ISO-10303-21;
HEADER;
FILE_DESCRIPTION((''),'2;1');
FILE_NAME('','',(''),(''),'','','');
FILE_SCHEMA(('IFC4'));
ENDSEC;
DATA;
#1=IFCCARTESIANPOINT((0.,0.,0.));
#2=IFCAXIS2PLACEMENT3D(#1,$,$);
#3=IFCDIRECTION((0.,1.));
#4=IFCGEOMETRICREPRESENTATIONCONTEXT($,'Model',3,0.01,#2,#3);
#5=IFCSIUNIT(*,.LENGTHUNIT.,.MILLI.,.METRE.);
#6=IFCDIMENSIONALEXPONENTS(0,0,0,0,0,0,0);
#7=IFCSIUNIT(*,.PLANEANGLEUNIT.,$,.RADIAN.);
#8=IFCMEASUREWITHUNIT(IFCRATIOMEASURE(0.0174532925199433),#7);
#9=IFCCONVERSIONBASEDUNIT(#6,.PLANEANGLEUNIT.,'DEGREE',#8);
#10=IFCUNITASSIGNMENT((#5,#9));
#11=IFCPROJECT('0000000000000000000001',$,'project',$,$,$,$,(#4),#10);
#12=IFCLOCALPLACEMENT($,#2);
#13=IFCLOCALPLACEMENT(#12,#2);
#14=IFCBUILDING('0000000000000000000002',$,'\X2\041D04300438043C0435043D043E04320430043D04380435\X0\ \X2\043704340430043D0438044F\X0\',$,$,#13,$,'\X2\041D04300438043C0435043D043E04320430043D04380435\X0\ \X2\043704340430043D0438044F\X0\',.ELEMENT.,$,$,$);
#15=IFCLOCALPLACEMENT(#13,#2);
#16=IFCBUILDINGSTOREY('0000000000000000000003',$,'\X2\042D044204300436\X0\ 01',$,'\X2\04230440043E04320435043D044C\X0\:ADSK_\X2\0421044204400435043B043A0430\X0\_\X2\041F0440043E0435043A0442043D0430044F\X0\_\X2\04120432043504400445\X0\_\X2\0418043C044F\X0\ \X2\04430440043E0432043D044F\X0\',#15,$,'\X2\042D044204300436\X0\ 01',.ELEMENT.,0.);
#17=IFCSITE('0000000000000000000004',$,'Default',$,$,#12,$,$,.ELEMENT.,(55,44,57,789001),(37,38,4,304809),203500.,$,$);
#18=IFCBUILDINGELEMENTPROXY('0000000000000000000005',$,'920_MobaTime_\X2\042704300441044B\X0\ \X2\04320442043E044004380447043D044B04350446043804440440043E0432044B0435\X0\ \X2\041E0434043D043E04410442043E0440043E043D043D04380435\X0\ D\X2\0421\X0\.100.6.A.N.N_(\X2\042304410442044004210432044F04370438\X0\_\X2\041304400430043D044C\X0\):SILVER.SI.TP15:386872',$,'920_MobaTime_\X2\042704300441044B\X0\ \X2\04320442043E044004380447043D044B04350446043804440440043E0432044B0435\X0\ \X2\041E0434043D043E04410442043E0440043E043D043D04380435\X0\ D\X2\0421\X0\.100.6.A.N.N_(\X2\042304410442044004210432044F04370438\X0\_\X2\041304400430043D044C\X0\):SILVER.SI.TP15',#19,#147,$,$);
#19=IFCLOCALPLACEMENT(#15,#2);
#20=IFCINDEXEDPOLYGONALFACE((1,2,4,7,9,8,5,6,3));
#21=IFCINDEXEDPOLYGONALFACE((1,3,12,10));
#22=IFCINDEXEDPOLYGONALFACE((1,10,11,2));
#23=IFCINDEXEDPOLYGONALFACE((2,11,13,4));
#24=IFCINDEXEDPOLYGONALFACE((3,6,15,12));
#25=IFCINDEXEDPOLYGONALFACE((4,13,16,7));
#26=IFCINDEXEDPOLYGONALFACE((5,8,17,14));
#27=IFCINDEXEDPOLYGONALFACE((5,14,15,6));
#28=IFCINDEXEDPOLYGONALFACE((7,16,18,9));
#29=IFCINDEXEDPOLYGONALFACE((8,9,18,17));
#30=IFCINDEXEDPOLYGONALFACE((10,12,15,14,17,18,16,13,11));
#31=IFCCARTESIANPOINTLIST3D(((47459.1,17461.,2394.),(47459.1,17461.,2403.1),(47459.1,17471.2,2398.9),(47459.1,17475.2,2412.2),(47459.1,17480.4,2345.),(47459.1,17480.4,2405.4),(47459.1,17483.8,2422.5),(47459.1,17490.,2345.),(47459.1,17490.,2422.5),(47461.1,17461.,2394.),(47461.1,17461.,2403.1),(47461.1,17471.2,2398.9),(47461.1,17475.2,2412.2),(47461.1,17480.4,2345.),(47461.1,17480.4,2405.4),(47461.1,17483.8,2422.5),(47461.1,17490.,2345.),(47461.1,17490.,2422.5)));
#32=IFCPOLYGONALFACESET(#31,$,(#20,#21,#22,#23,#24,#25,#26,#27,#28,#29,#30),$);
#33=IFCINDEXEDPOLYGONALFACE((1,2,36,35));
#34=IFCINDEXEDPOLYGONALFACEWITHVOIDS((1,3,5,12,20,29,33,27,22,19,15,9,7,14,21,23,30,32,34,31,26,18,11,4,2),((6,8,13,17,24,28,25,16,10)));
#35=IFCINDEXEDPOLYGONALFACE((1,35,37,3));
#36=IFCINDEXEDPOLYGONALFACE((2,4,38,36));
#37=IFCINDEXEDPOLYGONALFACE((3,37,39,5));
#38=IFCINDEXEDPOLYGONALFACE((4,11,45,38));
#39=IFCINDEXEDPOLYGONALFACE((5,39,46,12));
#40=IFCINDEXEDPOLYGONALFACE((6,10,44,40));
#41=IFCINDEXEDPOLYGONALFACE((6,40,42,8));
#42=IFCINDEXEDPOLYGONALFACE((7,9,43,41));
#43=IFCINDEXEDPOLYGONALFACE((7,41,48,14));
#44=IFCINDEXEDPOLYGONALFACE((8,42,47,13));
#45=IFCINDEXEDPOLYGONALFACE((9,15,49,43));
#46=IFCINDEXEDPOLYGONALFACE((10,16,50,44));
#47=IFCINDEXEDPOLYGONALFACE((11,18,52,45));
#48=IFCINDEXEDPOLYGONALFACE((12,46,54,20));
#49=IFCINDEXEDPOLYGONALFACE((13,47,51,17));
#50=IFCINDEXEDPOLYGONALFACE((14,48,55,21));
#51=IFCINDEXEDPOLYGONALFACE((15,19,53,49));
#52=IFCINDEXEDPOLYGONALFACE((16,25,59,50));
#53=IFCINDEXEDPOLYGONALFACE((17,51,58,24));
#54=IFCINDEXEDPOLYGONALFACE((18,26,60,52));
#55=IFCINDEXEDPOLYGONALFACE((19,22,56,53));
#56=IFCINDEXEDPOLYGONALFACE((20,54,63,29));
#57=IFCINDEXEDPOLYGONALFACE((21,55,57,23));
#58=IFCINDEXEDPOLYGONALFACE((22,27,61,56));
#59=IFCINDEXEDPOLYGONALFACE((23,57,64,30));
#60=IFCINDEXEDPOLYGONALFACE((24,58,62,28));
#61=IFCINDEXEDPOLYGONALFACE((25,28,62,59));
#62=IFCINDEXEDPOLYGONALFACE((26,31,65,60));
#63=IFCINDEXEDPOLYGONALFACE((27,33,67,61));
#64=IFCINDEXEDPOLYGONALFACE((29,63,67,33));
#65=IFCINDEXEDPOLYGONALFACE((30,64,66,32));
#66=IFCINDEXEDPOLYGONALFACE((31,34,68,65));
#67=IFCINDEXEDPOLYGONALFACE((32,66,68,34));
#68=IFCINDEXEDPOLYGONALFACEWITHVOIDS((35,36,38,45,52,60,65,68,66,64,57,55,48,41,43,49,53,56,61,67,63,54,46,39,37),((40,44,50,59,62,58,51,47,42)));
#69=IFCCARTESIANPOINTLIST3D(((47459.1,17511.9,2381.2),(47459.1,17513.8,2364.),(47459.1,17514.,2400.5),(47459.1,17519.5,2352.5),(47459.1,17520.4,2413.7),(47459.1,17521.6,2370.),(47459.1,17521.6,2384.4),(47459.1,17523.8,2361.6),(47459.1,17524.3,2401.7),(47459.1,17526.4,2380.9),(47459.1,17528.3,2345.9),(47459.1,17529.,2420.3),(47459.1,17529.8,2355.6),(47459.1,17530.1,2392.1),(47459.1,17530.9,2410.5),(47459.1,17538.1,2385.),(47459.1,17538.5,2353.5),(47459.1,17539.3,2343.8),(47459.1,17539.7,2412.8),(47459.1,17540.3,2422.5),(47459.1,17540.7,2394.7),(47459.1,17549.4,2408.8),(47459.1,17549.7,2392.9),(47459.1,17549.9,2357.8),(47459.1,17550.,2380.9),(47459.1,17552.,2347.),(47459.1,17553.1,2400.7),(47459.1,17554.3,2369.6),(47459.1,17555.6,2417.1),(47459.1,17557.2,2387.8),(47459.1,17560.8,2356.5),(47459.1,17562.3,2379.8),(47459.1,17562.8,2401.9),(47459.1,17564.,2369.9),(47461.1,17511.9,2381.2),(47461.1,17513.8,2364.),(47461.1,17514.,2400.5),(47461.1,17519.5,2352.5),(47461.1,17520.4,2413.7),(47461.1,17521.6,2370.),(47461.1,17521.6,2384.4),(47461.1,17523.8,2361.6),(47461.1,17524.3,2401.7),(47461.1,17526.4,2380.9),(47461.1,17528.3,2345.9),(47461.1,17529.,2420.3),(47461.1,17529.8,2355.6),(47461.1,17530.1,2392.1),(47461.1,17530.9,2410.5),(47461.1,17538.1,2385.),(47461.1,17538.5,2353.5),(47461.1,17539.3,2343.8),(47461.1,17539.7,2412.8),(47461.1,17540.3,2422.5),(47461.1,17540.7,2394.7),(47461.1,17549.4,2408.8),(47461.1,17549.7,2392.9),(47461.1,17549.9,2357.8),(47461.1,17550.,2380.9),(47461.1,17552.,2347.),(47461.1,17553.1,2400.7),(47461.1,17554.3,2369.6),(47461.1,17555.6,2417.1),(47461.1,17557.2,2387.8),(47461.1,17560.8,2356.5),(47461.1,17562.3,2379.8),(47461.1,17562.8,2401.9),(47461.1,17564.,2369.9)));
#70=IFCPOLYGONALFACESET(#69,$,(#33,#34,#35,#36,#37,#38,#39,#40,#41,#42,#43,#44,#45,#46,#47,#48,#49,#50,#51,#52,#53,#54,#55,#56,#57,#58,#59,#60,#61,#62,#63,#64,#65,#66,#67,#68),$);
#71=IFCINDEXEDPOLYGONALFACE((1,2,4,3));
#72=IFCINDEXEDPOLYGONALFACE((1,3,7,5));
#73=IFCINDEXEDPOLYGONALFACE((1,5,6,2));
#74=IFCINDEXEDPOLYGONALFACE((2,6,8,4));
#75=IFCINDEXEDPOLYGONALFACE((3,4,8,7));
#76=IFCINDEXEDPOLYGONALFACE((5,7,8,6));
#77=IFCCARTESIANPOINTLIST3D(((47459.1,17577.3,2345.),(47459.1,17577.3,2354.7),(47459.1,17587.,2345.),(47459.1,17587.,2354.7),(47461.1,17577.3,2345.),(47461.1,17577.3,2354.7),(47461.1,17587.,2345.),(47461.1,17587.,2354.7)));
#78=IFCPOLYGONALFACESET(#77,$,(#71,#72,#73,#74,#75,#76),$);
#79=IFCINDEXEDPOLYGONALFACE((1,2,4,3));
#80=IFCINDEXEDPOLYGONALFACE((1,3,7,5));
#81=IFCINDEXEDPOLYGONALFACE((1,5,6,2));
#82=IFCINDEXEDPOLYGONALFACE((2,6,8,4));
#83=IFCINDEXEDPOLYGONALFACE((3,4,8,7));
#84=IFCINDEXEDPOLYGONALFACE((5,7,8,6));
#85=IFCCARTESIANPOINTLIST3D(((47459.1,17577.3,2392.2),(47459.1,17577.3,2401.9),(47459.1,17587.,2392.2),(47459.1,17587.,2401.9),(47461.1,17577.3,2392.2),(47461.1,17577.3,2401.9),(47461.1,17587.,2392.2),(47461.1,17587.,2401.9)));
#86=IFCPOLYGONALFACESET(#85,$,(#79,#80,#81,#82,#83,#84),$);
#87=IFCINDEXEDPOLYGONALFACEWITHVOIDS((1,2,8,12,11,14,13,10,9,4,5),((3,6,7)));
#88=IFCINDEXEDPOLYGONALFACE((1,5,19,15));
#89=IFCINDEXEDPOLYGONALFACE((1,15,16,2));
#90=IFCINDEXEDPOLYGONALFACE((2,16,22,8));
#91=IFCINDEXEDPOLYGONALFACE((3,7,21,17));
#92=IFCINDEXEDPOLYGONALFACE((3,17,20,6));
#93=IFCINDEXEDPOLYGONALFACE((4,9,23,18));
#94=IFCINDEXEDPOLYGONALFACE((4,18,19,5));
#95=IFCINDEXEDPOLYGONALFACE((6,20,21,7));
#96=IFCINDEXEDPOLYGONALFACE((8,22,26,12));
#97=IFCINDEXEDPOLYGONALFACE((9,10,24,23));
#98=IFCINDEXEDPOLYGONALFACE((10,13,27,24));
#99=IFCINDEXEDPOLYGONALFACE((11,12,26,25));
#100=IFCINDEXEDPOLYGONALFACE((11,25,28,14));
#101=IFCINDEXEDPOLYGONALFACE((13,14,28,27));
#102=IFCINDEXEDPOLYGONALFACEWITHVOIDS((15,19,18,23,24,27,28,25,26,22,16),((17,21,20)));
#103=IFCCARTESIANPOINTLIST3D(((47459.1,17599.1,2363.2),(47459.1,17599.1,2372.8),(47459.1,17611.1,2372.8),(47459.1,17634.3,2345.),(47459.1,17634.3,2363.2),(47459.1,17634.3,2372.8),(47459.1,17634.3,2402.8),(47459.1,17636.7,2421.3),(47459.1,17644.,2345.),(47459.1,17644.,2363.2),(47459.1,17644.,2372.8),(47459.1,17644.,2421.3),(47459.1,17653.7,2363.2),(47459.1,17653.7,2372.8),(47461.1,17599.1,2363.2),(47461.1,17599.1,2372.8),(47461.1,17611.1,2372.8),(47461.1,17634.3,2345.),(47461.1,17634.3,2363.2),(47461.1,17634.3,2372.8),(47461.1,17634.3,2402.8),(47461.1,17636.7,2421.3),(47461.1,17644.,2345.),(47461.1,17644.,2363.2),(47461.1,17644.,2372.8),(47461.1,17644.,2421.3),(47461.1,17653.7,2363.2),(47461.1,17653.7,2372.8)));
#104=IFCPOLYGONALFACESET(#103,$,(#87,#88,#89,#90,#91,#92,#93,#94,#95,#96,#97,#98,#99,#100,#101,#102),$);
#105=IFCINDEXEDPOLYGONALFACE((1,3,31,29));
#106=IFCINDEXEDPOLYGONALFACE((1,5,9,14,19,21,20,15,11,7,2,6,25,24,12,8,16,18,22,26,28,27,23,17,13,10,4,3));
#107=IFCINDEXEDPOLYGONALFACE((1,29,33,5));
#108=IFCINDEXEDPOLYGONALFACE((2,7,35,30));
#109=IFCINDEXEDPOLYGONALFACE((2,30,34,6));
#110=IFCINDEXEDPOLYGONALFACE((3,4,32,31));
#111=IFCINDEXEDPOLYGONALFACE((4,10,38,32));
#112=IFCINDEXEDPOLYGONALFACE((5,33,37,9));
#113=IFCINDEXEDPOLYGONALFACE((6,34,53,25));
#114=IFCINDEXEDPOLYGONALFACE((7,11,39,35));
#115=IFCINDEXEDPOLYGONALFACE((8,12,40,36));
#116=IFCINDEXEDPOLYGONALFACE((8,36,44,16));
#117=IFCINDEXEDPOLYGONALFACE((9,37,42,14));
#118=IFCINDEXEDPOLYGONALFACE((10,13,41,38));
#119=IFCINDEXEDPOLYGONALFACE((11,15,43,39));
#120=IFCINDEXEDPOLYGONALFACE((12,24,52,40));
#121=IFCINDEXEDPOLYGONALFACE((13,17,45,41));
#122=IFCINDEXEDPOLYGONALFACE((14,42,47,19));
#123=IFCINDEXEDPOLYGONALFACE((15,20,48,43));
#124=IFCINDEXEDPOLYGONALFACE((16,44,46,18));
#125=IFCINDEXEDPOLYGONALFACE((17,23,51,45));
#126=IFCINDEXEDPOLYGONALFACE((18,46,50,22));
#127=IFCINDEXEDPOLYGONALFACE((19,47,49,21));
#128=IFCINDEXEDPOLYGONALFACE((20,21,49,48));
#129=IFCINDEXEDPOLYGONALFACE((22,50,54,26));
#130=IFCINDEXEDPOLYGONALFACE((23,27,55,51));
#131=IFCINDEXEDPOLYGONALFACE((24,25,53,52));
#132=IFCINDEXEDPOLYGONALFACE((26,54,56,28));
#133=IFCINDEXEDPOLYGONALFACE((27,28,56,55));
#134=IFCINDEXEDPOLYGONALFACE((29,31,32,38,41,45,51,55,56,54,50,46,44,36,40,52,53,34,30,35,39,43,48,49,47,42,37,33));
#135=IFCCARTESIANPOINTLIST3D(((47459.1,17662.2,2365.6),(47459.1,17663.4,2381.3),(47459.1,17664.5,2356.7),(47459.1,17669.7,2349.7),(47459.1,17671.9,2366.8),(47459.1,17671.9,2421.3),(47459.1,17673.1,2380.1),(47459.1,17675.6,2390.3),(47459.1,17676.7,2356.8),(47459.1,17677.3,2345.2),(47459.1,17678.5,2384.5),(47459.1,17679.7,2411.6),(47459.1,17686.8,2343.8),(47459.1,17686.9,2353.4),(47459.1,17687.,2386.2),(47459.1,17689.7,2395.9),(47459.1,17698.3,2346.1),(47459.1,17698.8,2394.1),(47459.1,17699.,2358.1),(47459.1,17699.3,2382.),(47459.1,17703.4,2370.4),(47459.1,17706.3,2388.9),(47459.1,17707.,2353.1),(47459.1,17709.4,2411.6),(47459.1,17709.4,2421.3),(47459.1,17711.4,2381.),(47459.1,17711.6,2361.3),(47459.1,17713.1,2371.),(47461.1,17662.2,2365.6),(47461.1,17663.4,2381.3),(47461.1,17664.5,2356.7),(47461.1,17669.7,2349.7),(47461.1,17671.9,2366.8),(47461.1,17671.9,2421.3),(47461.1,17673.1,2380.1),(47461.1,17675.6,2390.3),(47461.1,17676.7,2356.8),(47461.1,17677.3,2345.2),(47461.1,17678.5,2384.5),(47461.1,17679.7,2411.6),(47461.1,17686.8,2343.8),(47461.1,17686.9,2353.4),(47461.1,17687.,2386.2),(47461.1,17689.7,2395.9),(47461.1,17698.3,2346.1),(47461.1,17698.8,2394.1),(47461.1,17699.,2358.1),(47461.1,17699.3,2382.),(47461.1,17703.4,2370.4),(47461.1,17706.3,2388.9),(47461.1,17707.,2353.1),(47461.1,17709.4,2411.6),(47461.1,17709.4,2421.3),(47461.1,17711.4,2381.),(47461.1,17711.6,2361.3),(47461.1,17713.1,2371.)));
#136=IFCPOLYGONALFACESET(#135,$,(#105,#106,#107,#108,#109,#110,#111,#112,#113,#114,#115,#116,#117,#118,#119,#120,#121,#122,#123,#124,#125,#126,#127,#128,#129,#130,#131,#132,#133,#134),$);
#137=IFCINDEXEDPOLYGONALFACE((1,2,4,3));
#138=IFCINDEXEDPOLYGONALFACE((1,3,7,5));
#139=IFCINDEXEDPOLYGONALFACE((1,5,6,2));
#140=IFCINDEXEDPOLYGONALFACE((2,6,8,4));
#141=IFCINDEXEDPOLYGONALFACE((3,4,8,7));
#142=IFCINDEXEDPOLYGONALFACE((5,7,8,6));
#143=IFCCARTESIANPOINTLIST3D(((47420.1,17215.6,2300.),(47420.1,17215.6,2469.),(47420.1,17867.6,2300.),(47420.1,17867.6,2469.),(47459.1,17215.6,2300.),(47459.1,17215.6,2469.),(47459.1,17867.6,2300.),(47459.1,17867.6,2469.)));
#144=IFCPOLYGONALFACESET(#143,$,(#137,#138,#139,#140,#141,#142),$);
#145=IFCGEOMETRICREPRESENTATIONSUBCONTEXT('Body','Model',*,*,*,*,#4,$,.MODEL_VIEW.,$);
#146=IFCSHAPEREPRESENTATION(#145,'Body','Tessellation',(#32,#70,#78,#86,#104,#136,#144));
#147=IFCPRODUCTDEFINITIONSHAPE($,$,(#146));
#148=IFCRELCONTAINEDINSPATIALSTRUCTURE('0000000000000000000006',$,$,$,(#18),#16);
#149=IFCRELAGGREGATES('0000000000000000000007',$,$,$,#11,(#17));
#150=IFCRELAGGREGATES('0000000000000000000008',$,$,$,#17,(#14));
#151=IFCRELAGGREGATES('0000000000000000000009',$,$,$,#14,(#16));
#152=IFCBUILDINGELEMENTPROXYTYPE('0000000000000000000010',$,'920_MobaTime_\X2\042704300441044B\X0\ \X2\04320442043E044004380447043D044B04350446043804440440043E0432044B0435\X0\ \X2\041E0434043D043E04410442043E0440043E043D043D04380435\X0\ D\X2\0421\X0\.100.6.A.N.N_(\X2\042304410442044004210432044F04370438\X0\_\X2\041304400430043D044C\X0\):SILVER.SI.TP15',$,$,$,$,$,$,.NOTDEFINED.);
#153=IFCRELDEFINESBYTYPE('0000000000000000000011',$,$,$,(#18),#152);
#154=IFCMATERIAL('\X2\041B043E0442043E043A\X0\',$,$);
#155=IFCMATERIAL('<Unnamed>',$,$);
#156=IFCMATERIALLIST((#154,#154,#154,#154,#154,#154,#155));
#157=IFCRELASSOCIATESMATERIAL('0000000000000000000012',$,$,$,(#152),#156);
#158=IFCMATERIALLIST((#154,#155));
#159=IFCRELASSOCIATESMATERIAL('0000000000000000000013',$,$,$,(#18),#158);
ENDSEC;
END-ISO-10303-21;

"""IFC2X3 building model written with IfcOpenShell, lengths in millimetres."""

from ifc_helpers import new_model, entity, si_unit, converted_unit, direction, frame, origin, origin_2d_with_axis, place, context, subcontext, project, spatial, polyline, rectangle, outline, extrude, source, transform, mapped, material, material_list, type_object, type_shapes, element, save


model = new_model("IFC2X3")

# Units and contexts
model_context = context("Model", 3, precision=0.01, world=origin(), true_north=direction((0.0, 1.0)))
body_context = subcontext(model_context, "Body", "Model", "MODEL_VIEW")
ifc_project = project(units=[si_unit("LENGTHUNIT", "METRE", prefix="MILLI"), converted_unit("PLANEANGLEUNIT", "DEGREE", entity("IfcRatioMeasure", 0.0174532925199433), si_unit("PLANEANGLEUNIT", "RADIAN"), dimensions=[0, 0, 0, 0, 0, 0, 0])], contexts=[model_context])

# Site, building, storey
site_placement = place(None, origin())
site = spatial("IfcSite", under=ifc_project, at=site_placement, Name="Default", CompositionType="ELEMENT", RefLatitude=(55, 44, 57, 789001), RefLongitude=(37, 38, 4, 304809), RefElevation=203500.0)
building_placement = place(site_placement, origin())
building = spatial("IfcBuilding", under=site, at=building_placement, Name="Наименование здания", LongName="Наименование здания", CompositionType="ELEMENT")
storey_placement = place(building_placement, origin())
storey = spatial("IfcBuildingStorey", under=building, at=storey_placement, Name="Этаж 01", ObjectType="Уровень:ADSK_Стрелка_Проектная_Вверх_Имя уровня", LongName="Этаж 01", CompositionType="ELEMENT", Elevation=0.0)

# Building element proxy
ifc_material_1 = material(Name="Лоток")
ifc_material_2 = material(Name="<Unnamed>")
ifc_material_list_1 = material_list([ifc_material_1, ifc_material_1, ifc_material_1, ifc_material_1, ifc_material_1, ifc_material_1, ifc_material_2])
building_element_proxy_type = type_object("IfcBuildingElementProxyType", Name="920_MobaTime_Часы вторичныецифровые Односторонние DС.100.6.A.N.N_(УстрСвязи_Грань):SILVER.SI.TP15", PredefinedType="NOTDEFINED", material=ifc_material_list_1)
shared_shape = source(origin(), body_context, "Body", "SweptSolid", [
    extrude(outline(polyline([(-49.3, -13.1), (28.2, -13.1), (28.2, -6.8), (17.9, 1.8), (8.8, 16.0), (-0.3, 16.0), (4.6, 5.8), (11.1, -3.4), (-49.3, -3.4), (-49.3, -13.1)])), frame((-64.6, 9.8, 39.0), z_axis=(0.0, 0.0, 1.0), x_axis=(0.0, 1.0, 0.0)), (0.0, 0.0, 1.0), 2.0),
    extrude(outline(polyline([(2.2, -27.6), (19.0, -27.6), (30.5, -16.1), (33.3, -4.9), (31.0, 5.8), (21.8, 17.2), (5.2, 27.3), (-11.1, 33.0), (-24.0, 32.7), (-33.6, 27.6), (-40.3, 18.6), (-42.8, 5.7), (-38.0, -6.3), (-27.2, -14.9), (-17.5, -17.7), (-8.2, -16.4), (-0.3, -11.9), (5.1, -4.5), (7.3, 6.2), (4.0, 17.2), (18.4, 7.3), (23.6, -2.4), (22.0, -11.4), (14.2, -18.4), (5.3, -18.3), (2.2, -27.6)]), holes=[polyline([(-9.0, 23.3), (-1.3, 14.3), (-2.5, 2.0), (-11.4, -7.0), (-23.4, -6.0), (-32.2, 2.9), (-31.2, 15.1), (-25.6, 22.1), (-17.5, 24.9), (-9.0, 23.3)])]), frame((-2.7, 3.6, 39.0), z_axis=(0.0, 0.0, 1.0), x_axis=(-0.427649, 0.903945, 0.0)), (0.0, 0.0, 1.0), 2.0),
    extrude(rectangle(XDim=9.7, YDim=9.7, at=origin_2d_with_axis()), frame((40.6, -34.7, 39.0)), (0.0, 0.0, 1.0), 2.0),
    extrude(rectangle(XDim=9.7, YDim=9.7, at=origin_2d_with_axis()), frame((40.6, 12.6, 39.0)), (0.0, 0.0, 1.0), 2.0),
    extrude(outline(polyline([(-0.9, -28.1), (8.8, -28.1), (8.8, -9.9), (18.5, -9.9), (18.5, -0.2), (8.8, -0.2), (8.8, 48.3), (1.5, 48.3), (-36.0, -0.2), (-36.0, -9.9), (-0.9, -9.9), (-0.9, -28.1)]), holes=[polyline([(-0.9, -0.2), (-24.1, -0.2), (-0.9, 29.7), (-0.9, -0.2)])]), frame((93.6, -11.4, 39.0)), (0.0, 0.0, 1.0), 2.0),
    extrude(outline(polyline([(3.3, -28.3), (12.5, -28.3), (20.5, -25.0), (26.8, -18.9), (30.7, -10.0), (31.4, 1.6), (26.9, 11.8), (20.1, 18.4), (11.1, 22.3), (1.0, 23.3), (-7.9, 20.4), (-14.9, 14.5), (-18.9, 6.2), (-17.1, -9.0), (-36.7, 0.5), (-29.1, 29.2), (-38.5, 31.7), (-48.1, -4.6), (-11.6, -23.1), (-8.0, -14.0), (-10.8, -7.6), (-10.2, 1.1), (-3.0, 11.8), (9.2, 12.8), (20.0, 5.5), (21.4, -7.5), (15.5, -16.4), (4.6, -18.6), (3.3, -28.3)])), frame((147.1, -8.5, 39.0), z_axis=(0.0, 0.0, 1.0), x_axis=(0.256974, -0.966418, 0.0)), (0.0, 0.0, 1.0), 2.0),
    extrude(rectangle(XDim=652.0, YDim=169.0, at=origin_2d_with_axis()), frame((0.0, 0.0, 0.0), z_axis=(0.0, 0.0, 1.0), x_axis=(-1.0, 0.0, 0.0)), (0.0, 0.0, 1.0), 39.0),
])
type_shapes(building_element_proxy_type, [shared_shape])
ifc_material_list_2 = material_list([ifc_material_1, ifc_material_2])
for number, where, z_axis, x_axis, name in (
    (1, (47420.1, 17541.6, 2384.5), (1.0, 0.0, 0.0), (0.0, 1.0, 0.0), "920_MobaTime_Часы вторичныецифровые Односторонние DС.100.6.A.N.N_(УстрСвязи_Грань):SILVER.SI.TP15:386872"),
):
    element("IfcBuildingElementProxy", number, at=place(storey_placement, frame(where, z_axis=z_axis, x_axis=x_axis)), inside=storey, type_object=building_element_proxy_type, material=ifc_material_list_2, Name=name, ObjectType="920_MobaTime_Часы вторичныецифровые Односторонние DС.100.6.A.N.N_(УстрСвязи_Грань):SILVER.SI.TP15", context=body_context, shape_type="MappedRepresentation", body=[
        mapped(shared_shape, transform((0.0, 0.0, 0.0), scale=1.0)),
    ])

save(model, "model.ifc")
